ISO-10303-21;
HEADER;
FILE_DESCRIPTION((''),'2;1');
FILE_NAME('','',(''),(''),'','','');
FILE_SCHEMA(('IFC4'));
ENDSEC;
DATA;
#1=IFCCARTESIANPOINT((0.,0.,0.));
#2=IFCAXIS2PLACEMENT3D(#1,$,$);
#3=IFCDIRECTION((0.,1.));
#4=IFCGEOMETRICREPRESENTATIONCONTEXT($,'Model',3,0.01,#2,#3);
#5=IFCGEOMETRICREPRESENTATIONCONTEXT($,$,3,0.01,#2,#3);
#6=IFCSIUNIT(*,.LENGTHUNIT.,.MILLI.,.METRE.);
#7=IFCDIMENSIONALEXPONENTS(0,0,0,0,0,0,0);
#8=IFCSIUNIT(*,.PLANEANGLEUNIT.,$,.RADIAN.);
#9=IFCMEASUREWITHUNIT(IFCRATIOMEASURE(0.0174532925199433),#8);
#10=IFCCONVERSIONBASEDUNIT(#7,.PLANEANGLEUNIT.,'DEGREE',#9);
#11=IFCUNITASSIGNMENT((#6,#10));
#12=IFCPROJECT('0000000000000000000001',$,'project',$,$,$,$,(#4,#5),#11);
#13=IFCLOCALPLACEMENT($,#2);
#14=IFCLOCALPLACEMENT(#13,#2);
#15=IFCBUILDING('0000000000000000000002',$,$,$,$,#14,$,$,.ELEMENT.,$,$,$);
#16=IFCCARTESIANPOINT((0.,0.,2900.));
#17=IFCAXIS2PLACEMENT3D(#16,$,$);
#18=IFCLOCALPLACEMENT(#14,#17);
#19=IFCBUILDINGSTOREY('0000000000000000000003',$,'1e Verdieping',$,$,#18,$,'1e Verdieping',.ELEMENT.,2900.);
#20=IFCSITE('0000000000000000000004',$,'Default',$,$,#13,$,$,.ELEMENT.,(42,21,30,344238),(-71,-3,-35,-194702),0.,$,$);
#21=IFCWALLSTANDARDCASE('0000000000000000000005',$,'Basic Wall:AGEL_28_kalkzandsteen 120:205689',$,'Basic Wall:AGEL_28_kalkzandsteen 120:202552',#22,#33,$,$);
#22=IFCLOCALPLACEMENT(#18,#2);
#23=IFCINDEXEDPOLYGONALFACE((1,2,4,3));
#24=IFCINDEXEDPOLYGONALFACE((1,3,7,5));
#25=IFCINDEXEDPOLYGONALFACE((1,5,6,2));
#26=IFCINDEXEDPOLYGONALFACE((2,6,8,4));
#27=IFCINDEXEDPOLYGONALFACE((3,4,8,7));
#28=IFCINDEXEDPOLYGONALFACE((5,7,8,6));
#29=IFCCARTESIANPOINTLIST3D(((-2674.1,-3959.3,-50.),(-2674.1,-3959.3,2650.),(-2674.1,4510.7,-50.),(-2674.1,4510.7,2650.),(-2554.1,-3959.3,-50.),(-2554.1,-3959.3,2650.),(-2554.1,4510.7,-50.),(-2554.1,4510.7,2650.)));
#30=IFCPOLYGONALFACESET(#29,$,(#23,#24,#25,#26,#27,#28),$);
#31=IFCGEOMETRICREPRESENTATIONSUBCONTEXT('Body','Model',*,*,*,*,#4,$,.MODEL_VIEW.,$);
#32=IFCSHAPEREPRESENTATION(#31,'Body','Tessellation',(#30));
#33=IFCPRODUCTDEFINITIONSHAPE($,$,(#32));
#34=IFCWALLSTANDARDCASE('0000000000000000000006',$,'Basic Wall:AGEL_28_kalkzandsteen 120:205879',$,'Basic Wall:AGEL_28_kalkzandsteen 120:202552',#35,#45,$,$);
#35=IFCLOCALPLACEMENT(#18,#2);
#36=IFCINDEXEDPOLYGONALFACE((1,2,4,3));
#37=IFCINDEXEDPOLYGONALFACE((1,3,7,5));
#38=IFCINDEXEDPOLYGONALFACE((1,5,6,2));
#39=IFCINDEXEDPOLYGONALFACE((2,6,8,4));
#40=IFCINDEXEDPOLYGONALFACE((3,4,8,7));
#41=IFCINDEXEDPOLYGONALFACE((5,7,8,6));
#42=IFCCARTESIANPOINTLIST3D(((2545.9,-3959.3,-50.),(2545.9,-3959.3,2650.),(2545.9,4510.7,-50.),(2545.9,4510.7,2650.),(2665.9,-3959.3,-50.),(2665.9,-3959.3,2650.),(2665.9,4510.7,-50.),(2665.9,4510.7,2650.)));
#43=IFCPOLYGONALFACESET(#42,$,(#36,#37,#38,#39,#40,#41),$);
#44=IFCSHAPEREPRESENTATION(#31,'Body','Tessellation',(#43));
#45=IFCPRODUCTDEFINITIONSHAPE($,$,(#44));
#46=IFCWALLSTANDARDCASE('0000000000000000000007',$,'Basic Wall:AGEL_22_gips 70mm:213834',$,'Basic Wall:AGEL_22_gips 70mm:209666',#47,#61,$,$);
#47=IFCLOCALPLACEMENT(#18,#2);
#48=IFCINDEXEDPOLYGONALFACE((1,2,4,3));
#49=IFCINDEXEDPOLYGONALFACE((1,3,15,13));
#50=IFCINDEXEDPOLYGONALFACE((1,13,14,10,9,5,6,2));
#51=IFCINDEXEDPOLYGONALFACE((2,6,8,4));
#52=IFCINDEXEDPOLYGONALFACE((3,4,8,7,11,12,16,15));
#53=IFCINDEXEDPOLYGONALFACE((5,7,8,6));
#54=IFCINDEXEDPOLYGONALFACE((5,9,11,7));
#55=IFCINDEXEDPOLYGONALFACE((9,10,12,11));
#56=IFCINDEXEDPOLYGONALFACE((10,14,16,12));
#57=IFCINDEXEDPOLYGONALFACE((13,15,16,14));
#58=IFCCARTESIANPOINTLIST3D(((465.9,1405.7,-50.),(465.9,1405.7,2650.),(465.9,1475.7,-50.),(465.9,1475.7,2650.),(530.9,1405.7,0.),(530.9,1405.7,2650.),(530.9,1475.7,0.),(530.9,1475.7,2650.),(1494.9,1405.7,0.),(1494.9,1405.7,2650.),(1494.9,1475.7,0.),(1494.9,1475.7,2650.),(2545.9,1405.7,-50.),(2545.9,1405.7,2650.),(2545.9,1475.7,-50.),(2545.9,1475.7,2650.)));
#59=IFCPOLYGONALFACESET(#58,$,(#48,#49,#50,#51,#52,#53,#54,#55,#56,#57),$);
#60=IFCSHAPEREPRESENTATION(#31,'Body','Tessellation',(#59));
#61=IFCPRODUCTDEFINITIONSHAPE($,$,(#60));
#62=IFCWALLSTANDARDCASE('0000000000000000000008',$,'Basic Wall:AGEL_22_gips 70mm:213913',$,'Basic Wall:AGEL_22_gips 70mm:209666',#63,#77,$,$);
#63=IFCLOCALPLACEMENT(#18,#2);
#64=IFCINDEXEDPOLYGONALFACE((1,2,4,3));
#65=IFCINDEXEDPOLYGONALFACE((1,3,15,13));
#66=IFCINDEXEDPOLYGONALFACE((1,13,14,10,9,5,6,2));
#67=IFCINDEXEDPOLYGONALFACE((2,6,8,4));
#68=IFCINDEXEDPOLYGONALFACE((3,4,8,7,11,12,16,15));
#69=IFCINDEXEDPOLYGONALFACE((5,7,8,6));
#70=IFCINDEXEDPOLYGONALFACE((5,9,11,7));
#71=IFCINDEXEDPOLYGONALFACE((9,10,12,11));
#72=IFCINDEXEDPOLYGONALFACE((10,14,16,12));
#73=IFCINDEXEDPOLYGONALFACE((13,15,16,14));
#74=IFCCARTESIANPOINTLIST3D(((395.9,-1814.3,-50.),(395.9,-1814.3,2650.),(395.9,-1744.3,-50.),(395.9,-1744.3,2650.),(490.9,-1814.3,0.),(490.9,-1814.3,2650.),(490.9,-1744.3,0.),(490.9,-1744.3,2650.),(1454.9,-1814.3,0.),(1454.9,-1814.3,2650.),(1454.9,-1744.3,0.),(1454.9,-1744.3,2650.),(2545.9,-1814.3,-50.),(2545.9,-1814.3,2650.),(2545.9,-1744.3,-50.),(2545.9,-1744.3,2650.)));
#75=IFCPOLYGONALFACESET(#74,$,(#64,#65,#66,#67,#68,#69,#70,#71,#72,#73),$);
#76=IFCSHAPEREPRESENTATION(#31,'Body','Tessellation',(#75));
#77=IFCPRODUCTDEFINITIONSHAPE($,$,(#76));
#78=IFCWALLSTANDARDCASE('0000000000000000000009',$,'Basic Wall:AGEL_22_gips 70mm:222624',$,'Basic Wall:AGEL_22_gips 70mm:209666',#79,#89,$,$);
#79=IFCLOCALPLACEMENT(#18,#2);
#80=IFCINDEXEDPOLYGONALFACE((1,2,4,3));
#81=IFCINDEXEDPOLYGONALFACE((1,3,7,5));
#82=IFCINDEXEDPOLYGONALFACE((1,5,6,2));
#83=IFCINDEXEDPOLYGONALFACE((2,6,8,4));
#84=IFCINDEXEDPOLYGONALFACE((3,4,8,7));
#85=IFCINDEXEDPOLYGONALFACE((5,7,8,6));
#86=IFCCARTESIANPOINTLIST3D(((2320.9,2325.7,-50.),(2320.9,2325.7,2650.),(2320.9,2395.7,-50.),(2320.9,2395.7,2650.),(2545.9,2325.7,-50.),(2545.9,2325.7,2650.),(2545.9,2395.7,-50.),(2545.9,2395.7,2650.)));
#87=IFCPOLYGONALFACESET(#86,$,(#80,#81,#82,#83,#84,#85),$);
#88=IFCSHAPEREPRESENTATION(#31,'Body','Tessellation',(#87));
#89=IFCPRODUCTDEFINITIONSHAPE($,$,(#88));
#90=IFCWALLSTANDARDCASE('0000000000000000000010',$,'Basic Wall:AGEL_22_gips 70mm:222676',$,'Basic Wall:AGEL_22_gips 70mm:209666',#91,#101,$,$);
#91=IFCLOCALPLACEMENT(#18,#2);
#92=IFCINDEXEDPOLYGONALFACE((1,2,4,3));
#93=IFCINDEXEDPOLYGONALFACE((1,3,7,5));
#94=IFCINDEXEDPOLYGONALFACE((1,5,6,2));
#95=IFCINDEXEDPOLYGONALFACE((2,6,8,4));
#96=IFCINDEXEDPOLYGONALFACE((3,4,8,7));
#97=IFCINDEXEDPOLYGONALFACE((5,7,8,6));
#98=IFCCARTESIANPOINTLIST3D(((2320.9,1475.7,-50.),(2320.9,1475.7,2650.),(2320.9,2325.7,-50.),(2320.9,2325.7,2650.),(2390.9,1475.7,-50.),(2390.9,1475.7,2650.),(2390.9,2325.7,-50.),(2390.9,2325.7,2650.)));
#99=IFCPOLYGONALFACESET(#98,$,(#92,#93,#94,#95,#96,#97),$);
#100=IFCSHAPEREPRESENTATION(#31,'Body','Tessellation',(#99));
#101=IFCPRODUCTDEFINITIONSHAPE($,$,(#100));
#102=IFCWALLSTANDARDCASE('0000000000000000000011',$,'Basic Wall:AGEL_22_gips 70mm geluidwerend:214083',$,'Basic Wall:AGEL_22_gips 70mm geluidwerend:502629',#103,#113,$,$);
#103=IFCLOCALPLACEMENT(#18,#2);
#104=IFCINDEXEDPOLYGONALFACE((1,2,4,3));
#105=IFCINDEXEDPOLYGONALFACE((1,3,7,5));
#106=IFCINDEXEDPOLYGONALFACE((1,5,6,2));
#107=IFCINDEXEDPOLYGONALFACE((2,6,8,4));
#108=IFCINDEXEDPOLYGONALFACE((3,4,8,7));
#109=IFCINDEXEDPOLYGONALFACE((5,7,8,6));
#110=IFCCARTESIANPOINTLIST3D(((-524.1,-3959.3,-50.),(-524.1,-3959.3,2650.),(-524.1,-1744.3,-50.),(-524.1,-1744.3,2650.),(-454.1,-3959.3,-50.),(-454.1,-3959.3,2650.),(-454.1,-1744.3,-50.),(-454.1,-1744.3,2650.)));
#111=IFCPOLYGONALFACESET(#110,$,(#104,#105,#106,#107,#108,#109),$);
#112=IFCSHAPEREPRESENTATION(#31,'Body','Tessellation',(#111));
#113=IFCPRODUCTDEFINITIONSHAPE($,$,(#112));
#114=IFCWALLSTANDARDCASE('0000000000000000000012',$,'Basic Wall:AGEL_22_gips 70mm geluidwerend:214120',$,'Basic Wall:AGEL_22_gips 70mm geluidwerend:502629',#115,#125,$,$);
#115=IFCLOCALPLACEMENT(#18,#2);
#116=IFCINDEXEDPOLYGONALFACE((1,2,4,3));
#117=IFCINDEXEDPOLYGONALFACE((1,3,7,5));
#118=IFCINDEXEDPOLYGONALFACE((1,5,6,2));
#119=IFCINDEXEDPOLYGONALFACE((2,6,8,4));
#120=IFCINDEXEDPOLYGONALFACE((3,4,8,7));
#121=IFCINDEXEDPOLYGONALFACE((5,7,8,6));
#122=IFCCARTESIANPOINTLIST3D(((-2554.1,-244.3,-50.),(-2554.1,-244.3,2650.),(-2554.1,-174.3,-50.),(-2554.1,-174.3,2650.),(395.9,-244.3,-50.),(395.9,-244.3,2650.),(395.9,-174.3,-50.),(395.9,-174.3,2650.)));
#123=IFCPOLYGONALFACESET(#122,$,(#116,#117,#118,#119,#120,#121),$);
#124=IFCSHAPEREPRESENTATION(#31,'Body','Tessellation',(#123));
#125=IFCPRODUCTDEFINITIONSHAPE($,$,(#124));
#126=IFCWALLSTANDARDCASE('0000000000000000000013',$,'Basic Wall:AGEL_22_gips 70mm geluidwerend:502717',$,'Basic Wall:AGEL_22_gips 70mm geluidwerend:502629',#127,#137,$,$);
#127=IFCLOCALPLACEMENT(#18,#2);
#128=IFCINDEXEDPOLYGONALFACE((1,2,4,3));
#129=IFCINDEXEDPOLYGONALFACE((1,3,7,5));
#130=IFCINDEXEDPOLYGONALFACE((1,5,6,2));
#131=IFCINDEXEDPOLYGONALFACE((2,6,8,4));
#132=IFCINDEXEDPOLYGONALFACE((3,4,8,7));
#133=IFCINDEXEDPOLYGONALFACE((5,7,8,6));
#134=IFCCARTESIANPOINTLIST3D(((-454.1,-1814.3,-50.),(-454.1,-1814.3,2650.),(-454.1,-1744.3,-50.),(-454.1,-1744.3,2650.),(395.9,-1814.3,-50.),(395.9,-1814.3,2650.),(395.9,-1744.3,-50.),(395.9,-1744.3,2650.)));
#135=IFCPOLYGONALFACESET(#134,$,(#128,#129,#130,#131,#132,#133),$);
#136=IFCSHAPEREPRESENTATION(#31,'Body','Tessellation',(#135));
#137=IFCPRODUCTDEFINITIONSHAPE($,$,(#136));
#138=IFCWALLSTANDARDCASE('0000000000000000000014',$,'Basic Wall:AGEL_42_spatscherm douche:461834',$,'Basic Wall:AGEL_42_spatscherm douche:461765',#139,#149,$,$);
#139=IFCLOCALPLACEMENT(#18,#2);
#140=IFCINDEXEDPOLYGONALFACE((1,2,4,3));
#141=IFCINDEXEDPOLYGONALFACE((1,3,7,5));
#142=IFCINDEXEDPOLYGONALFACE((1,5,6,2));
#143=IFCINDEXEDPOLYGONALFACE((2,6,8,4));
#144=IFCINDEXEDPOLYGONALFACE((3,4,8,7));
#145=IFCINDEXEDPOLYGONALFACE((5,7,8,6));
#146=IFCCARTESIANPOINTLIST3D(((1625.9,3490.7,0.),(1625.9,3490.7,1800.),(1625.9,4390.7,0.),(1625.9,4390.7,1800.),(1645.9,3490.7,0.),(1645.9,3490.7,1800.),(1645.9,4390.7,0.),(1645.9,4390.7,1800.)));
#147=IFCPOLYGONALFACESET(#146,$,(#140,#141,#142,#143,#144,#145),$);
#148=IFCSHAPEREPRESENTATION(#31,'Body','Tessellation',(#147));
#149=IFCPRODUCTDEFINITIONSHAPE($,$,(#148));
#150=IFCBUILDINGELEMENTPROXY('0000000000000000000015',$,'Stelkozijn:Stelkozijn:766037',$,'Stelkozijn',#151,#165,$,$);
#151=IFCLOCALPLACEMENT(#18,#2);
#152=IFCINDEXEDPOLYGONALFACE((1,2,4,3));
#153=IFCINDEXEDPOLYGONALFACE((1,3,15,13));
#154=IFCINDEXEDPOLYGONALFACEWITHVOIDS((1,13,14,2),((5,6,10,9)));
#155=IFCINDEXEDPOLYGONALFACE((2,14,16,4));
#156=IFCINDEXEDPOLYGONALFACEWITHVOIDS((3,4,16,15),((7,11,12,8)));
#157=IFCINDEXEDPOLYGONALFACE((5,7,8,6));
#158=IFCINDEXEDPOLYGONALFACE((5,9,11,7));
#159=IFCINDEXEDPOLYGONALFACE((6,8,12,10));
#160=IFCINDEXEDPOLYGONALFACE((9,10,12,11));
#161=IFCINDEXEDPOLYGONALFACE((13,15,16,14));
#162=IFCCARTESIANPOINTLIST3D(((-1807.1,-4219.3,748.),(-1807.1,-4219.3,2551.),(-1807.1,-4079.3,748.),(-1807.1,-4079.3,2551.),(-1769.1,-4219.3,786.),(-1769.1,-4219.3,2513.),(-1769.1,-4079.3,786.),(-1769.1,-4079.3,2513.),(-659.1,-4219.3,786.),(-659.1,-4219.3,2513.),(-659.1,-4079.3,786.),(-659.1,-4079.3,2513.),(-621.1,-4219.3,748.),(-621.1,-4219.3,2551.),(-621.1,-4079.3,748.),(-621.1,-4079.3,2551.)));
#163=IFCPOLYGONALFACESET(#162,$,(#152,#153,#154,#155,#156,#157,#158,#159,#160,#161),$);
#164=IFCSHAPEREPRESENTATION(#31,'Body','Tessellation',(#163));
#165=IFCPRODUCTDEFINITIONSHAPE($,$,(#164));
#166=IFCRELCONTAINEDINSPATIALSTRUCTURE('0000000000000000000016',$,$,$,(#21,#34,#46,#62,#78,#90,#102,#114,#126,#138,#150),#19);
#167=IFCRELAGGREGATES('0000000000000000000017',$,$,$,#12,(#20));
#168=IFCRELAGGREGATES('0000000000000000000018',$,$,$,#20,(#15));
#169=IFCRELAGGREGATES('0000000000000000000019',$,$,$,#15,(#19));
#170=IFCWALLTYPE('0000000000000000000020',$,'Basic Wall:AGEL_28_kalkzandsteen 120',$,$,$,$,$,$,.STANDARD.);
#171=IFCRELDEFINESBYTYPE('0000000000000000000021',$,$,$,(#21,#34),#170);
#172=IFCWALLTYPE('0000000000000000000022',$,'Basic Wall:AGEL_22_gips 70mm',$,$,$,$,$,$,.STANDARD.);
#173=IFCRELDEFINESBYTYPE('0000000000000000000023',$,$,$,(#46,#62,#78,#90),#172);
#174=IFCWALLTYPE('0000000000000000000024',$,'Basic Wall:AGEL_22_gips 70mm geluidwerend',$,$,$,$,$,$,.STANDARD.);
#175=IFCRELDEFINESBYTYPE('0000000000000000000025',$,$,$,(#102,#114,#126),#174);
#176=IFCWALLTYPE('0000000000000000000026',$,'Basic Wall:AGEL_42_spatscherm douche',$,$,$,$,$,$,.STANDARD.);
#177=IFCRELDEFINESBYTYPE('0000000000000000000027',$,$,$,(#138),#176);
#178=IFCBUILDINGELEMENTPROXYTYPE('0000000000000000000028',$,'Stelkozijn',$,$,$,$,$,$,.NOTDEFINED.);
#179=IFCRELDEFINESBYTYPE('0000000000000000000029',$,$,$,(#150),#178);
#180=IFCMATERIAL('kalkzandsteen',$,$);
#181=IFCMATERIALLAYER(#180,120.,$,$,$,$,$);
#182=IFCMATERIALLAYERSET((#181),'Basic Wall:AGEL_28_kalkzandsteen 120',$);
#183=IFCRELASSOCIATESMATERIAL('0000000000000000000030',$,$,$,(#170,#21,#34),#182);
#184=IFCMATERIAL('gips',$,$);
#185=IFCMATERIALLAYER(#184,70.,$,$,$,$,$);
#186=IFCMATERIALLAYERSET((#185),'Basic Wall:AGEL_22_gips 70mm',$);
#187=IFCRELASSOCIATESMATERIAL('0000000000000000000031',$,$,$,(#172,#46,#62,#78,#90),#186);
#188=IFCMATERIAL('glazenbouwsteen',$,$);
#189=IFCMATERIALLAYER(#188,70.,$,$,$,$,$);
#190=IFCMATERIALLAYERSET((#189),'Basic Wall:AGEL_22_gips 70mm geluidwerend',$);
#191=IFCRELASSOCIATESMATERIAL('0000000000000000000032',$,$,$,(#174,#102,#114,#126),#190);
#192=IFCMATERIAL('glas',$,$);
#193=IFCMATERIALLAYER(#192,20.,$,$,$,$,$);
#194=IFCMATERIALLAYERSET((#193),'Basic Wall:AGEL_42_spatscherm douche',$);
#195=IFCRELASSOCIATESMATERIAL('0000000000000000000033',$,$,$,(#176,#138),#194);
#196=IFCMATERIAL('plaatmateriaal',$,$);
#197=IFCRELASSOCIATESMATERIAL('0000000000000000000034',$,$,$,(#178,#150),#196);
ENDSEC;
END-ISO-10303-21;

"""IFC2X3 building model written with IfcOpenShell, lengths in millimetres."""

from ifc_helpers import new_model, entity, si_unit, converted_unit, direction, frame, frame_2d, origin, place, context, subcontext, project, spatial, polyline, rectangle, outline, extrude, source, transform, mapped, material, layer, layer_set, layer_usage, type_object, type_shapes, element, save


model = new_model("IFC2X3")

# Units and contexts
model_context = context("Model", 3, precision=0.01, world=origin(), true_north=direction((0.0, 1.0)))
context_of_model = context(None, 3, precision=0.01, world=origin(), true_north=direction((0.0, 1.0)))
body_context = subcontext(model_context, "Body", "Model", "MODEL_VIEW")
ifc_project = project(units=[si_unit("LENGTHUNIT", "METRE", prefix="MILLI"), converted_unit("PLANEANGLEUNIT", "DEGREE", entity("IfcRatioMeasure", 0.0174532925199433), si_unit("PLANEANGLEUNIT", "RADIAN"), dimensions=[0, 0, 0, 0, 0, 0, 0])], contexts=[model_context, context_of_model])

# Site, building, storey
site_placement = place(None, origin())
site = spatial("IfcSite", under=ifc_project, at=site_placement, Name="Default", CompositionType="ELEMENT", RefLatitude=(42, 21, 30, 344238), RefLongitude=(-71, -3, -35, -194702), RefElevation=0.0)
building_placement = place(site_placement, origin())
building = spatial("IfcBuilding", under=site, at=building_placement, CompositionType="ELEMENT")
storey_placement = place(building_placement, frame((0.0, 0.0, 2900.0)))
storey = spatial("IfcBuildingStorey", under=building, at=storey_placement, Name="1e Verdieping", LongName="1e Verdieping", CompositionType="ELEMENT", Elevation=2900.0)

# Walls
ifc_material_1 = material(Name="kalkzandsteen")
ifc_layer_1 = layer(ifc_material_1, 120.0)
ifc_layer_set_1 = layer_set([ifc_layer_1], Name="Basic Wall:AGEL_28_kalkzandsteen 120")
ifc_layer_usage_1 = layer_usage(ifc_layer_set_1, "AXIS2", "NEGATIVE", 60.0)
wall_type_1 = type_object("IfcWallType", Name="Basic Wall:AGEL_28_kalkzandsteen 120", PredefinedType="STANDARD", material=ifc_layer_set_1)
wall_1_placement = place(storey_placement, frame((-2614.1, -3959.3, -50.0), z_axis=(0.0, 0.0, 1.0), x_axis=(0.0, 1.0, 0.0)))
element("IfcWallStandardCase", 1, at=wall_1_placement, inside=storey, type_object=wall_type_1, material=ifc_layer_usage_1, Name="Basic Wall:AGEL_28_kalkzandsteen 120:205689", ObjectType="Basic Wall:AGEL_28_kalkzandsteen 120:202552", context=body_context, shape_type="SweptSolid", body=[
    extrude(rectangle(XDim=8470.0, YDim=120.0, at=frame_2d((4235.0, 0.0), x_axis=(-1.0, 0.0))), origin(), (0.0, 0.0, 1.0), 2700.0),
])
ifc_layer_usage_2 = layer_usage(ifc_layer_set_1, "AXIS2", "NEGATIVE", 60.0)
wall_2_placement = place(storey_placement, frame((2605.9, -3959.3, -50.0), z_axis=(0.0, 0.0, 1.0), x_axis=(0.0, 1.0, 0.0)))
element("IfcWallStandardCase", 2, at=wall_2_placement, inside=storey, type_object=wall_type_1, material=ifc_layer_usage_2, Name="Basic Wall:AGEL_28_kalkzandsteen 120:205879", ObjectType="Basic Wall:AGEL_28_kalkzandsteen 120:202552", context=body_context, shape_type="SweptSolid", body=[
    extrude(rectangle(XDim=8470.0, YDim=120.0, at=frame_2d((4235.0, 0.0), x_axis=(-1.0, 0.0))), origin(), (0.0, 0.0, 1.0), 2700.0),
])

# Walls, openings
ifc_material_2 = material(Name="gips")
ifc_layer_2 = layer(ifc_material_2, 70.0)
ifc_layer_set_2 = layer_set([ifc_layer_2], Name="Basic Wall:AGEL_22_gips 70mm")
ifc_layer_usage_3 = layer_usage(ifc_layer_set_2, "AXIS2", "NEGATIVE", 35.0)
wall_type_2 = type_object("IfcWallType", Name="Basic Wall:AGEL_22_gips 70mm", PredefinedType="STANDARD", material=ifc_layer_set_2)
wall_3_placement = place(storey_placement, frame((465.9, 1440.7, -50.0)))
wall_3 = element("IfcWallStandardCase", 3, at=wall_3_placement, inside=storey, type_object=wall_type_2, material=ifc_layer_usage_3, Name="Basic Wall:AGEL_22_gips 70mm:213834", ObjectType="Basic Wall:AGEL_22_gips 70mm:209666", context=body_context, shape_type="SweptSolid", body=[
    extrude(rectangle(XDim=2080.0, YDim=70.0, at=frame_2d((1040.0, 0.0), x_axis=(-1.0, 0.0))), origin(), (0.0, 0.0, 1.0), 2700.0),
])
opening_1_placement = place(wall_3_placement, frame((65.0, -535.0, 50.0)))
element("IfcOpeningElement", 4, at=opening_1_placement, cuts=wall_3, ObjectType="Opening", context=body_context, shape_type="SweptSolid", body=[
    extrude(rectangle(XDim=2723.0, YDim=964.0, at=frame_2d((0.0, 0.0), x_axis=(1.0, 0.0))), frame((482.0, 0.0, 1361.5), z_axis=(0.0, 1.0, 0.0), x_axis=(0.0, 0.0, -1.0)), (0.0, 0.0, 1.0), 1000.0),
])
ifc_layer_usage_4 = layer_usage(ifc_layer_set_2, "AXIS2", "POSITIVE", -35.0)
wall_4_placement = place(storey_placement, frame((395.9, -1779.3, -50.0)))
wall_4 = element("IfcWallStandardCase", 5, at=wall_4_placement, inside=storey, type_object=wall_type_2, material=ifc_layer_usage_4, Name="Basic Wall:AGEL_22_gips 70mm:213913", ObjectType="Basic Wall:AGEL_22_gips 70mm:209666", context=body_context, shape_type="SweptSolid", body=[
    extrude(rectangle(XDim=2150.0, YDim=70.0, at=frame_2d((1075.0, 0.0), x_axis=(-1.0, 0.0))), origin(), (0.0, 0.0, 1.0), 2700.0),
])
opening_2_placement = place(wall_4_placement, frame((95.0, -535.0, 50.0)))
element("IfcOpeningElement", 6, at=opening_2_placement, cuts=wall_4, ObjectType="Opening", context=body_context, shape_type="SweptSolid", body=[
    extrude(rectangle(XDim=2723.0, YDim=964.0, at=frame_2d((0.0, 0.0), x_axis=(0.0, 1.0))), frame((482.0, 0.0, 1361.5), z_axis=(0.0, 1.0, 0.0), x_axis=(1.0, 0.0, 0.0)), (0.0, 0.0, 1.0), 1000.0),
])

# Walls
ifc_layer_usage_5 = layer_usage(ifc_layer_set_2, "AXIS2", "NEGATIVE", 35.0)
wall_5_placement = place(storey_placement, frame((2320.9, 2360.7, -50.0)))
element("IfcWallStandardCase", 7, at=wall_5_placement, inside=storey, type_object=wall_type_2, material=ifc_layer_usage_5, Name="Basic Wall:AGEL_22_gips 70mm:222624", ObjectType="Basic Wall:AGEL_22_gips 70mm:209666", context=body_context, shape_type="SweptSolid", body=[
    extrude(rectangle(XDim=225.0, YDim=70.0, at=frame_2d((112.5, 0.0), x_axis=(-1.0, 0.0))), origin(), (0.0, 0.0, 1.0), 2700.0),
])
ifc_layer_usage_6 = layer_usage(ifc_layer_set_2, "AXIS2", "POSITIVE", -35.0)
wall_6_placement = place(storey_placement, frame((2355.9, 2325.7, -50.0), z_axis=(0.0, 0.0, 1.0), x_axis=(0.0, -1.0, 0.0)))
element("IfcWallStandardCase", 8, at=wall_6_placement, inside=storey, type_object=wall_type_2, material=ifc_layer_usage_6, Name="Basic Wall:AGEL_22_gips 70mm:222676", ObjectType="Basic Wall:AGEL_22_gips 70mm:209666", context=body_context, shape_type="SweptSolid", body=[
    extrude(rectangle(XDim=850.0, YDim=70.0, at=frame_2d((425.0, 0.0), x_axis=(-1.0, 0.0))), origin(), (0.0, 0.0, 1.0), 2700.0),
])
ifc_material_3 = material(Name="glazenbouwsteen")
ifc_layer_3 = layer(ifc_material_3, 70.0)
ifc_layer_set_3 = layer_set([ifc_layer_3], Name="Basic Wall:AGEL_22_gips 70mm geluidwerend")
ifc_layer_usage_7 = layer_usage(ifc_layer_set_3, "AXIS2", "POSITIVE", -35.0)
wall_type_3 = type_object("IfcWallType", Name="Basic Wall:AGEL_22_gips 70mm geluidwerend", PredefinedType="STANDARD", material=ifc_layer_set_3)
wall_7_placement = place(storey_placement, frame((-489.1, -3959.3, -50.0), z_axis=(0.0, 0.0, 1.0), x_axis=(0.0, 1.0, 0.0)))
element("IfcWallStandardCase", 9, at=wall_7_placement, inside=storey, type_object=wall_type_3, material=ifc_layer_usage_7, Name="Basic Wall:AGEL_22_gips 70mm geluidwerend:214083", ObjectType="Basic Wall:AGEL_22_gips 70mm geluidwerend:502629", context=body_context, shape_type="SweptSolid", body=[
    extrude(rectangle(XDim=2215.0, YDim=70.0, at=frame_2d((1107.5, 0.0), x_axis=(-1.0, 0.0))), origin(), (0.0, 0.0, 1.0), 2700.0),
])
ifc_layer_usage_8 = layer_usage(ifc_layer_set_3, "AXIS2", "POSITIVE", -35.0)
wall_8_placement = place(storey_placement, frame((-2554.1, -209.3, -50.0)))
element("IfcWallStandardCase", 10, at=wall_8_placement, inside=storey, type_object=wall_type_3, material=ifc_layer_usage_8, Name="Basic Wall:AGEL_22_gips 70mm geluidwerend:214120", ObjectType="Basic Wall:AGEL_22_gips 70mm geluidwerend:502629", context=body_context, shape_type="SweptSolid", body=[
    extrude(rectangle(XDim=2950.0, YDim=70.0, at=frame_2d((1475.0, 0.0), x_axis=(-1.0, 0.0))), origin(), (0.0, 0.0, 1.0), 2700.0),
])
ifc_layer_usage_9 = layer_usage(ifc_layer_set_3, "AXIS2", "POSITIVE", -35.0)
wall_9_placement = place(storey_placement, frame((-454.1, -1779.3, -50.0)))
element("IfcWallStandardCase", 11, at=wall_9_placement, inside=storey, type_object=wall_type_3, material=ifc_layer_usage_9, Name="Basic Wall:AGEL_22_gips 70mm geluidwerend:502717", ObjectType="Basic Wall:AGEL_22_gips 70mm geluidwerend:502629", context=body_context, shape_type="SweptSolid", body=[
    extrude(rectangle(XDim=850.0, YDim=70.0, at=frame_2d((425.0, 0.0), x_axis=(-1.0, 0.0))), origin(), (0.0, 0.0, 1.0), 2700.0),
])
ifc_material_4 = material(Name="glas")
ifc_layer_4 = layer(ifc_material_4, 20.0)
ifc_layer_set_4 = layer_set([ifc_layer_4], Name="Basic Wall:AGEL_42_spatscherm douche")
ifc_layer_usage_10 = layer_usage(ifc_layer_set_4, "AXIS2", "NEGATIVE", 10.0)
wall_type_4 = type_object("IfcWallType", Name="Basic Wall:AGEL_42_spatscherm douche", PredefinedType="STANDARD", material=ifc_layer_set_4)
wall_10_placement = place(storey_placement, frame((1635.9, 4390.7, 0.0), z_axis=(0.0, 0.0, 1.0), x_axis=(0.0, -1.0, 0.0)))
element("IfcWallStandardCase", 12, at=wall_10_placement, inside=storey, type_object=wall_type_4, material=ifc_layer_usage_10, Name="Basic Wall:AGEL_42_spatscherm douche:461834", ObjectType="Basic Wall:AGEL_42_spatscherm douche:461765", context=body_context, shape_type="SweptSolid", body=[
    extrude(rectangle(XDim=900.0, YDim=20.0, at=frame_2d((450.0, 0.0), x_axis=(-1.0, 0.0))), origin(), (0.0, 0.0, 1.0), 1800.0),
])

# Building element proxy
ifc_material_5 = material(Name="plaatmateriaal")
building_element_proxy_type_1 = type_object("IfcBuildingElementProxyType", Name="Stelkozijn", PredefinedType="NOTDEFINED", material=ifc_material_5)
shared_shape_1 = source(origin(), body_context, "Body", "SweptSolid", [
    extrude(outline(polyline([(-593.0, -901.5), (593.0, -901.5), (593.0, 901.5), (-593.0, 901.5), (-593.0, -901.5)]), holes=[polyline([(555.0, -863.5), (-555.0, -863.5), (-555.0, 863.5), (555.0, 863.5), (555.0, -863.5)])]), frame((593.0, 0.0, 901.5), z_axis=(0.0, 1.0, 0.0), x_axis=(1.0, 0.0, 0.0)), (0.0, 0.0, 1.0), 140.0),
])
type_shapes(building_element_proxy_type_1, [shared_shape_1])
proxy_1_placement = place(storey_placement, frame((-1807.1, -4219.3, 748.0)))
element("IfcBuildingElementProxy", 13, at=proxy_1_placement, inside=storey, type_object=building_element_proxy_type_1, material=ifc_material_5, Name="Stelkozijn:Stelkozijn:766037", ObjectType="Stelkozijn", context=body_context, shape_type="MappedRepresentation", body=[
    mapped(shared_shape_1, transform((0.0, 0.0, 0.0), scale=1.0)),
])

save(model, "model.ifc")
